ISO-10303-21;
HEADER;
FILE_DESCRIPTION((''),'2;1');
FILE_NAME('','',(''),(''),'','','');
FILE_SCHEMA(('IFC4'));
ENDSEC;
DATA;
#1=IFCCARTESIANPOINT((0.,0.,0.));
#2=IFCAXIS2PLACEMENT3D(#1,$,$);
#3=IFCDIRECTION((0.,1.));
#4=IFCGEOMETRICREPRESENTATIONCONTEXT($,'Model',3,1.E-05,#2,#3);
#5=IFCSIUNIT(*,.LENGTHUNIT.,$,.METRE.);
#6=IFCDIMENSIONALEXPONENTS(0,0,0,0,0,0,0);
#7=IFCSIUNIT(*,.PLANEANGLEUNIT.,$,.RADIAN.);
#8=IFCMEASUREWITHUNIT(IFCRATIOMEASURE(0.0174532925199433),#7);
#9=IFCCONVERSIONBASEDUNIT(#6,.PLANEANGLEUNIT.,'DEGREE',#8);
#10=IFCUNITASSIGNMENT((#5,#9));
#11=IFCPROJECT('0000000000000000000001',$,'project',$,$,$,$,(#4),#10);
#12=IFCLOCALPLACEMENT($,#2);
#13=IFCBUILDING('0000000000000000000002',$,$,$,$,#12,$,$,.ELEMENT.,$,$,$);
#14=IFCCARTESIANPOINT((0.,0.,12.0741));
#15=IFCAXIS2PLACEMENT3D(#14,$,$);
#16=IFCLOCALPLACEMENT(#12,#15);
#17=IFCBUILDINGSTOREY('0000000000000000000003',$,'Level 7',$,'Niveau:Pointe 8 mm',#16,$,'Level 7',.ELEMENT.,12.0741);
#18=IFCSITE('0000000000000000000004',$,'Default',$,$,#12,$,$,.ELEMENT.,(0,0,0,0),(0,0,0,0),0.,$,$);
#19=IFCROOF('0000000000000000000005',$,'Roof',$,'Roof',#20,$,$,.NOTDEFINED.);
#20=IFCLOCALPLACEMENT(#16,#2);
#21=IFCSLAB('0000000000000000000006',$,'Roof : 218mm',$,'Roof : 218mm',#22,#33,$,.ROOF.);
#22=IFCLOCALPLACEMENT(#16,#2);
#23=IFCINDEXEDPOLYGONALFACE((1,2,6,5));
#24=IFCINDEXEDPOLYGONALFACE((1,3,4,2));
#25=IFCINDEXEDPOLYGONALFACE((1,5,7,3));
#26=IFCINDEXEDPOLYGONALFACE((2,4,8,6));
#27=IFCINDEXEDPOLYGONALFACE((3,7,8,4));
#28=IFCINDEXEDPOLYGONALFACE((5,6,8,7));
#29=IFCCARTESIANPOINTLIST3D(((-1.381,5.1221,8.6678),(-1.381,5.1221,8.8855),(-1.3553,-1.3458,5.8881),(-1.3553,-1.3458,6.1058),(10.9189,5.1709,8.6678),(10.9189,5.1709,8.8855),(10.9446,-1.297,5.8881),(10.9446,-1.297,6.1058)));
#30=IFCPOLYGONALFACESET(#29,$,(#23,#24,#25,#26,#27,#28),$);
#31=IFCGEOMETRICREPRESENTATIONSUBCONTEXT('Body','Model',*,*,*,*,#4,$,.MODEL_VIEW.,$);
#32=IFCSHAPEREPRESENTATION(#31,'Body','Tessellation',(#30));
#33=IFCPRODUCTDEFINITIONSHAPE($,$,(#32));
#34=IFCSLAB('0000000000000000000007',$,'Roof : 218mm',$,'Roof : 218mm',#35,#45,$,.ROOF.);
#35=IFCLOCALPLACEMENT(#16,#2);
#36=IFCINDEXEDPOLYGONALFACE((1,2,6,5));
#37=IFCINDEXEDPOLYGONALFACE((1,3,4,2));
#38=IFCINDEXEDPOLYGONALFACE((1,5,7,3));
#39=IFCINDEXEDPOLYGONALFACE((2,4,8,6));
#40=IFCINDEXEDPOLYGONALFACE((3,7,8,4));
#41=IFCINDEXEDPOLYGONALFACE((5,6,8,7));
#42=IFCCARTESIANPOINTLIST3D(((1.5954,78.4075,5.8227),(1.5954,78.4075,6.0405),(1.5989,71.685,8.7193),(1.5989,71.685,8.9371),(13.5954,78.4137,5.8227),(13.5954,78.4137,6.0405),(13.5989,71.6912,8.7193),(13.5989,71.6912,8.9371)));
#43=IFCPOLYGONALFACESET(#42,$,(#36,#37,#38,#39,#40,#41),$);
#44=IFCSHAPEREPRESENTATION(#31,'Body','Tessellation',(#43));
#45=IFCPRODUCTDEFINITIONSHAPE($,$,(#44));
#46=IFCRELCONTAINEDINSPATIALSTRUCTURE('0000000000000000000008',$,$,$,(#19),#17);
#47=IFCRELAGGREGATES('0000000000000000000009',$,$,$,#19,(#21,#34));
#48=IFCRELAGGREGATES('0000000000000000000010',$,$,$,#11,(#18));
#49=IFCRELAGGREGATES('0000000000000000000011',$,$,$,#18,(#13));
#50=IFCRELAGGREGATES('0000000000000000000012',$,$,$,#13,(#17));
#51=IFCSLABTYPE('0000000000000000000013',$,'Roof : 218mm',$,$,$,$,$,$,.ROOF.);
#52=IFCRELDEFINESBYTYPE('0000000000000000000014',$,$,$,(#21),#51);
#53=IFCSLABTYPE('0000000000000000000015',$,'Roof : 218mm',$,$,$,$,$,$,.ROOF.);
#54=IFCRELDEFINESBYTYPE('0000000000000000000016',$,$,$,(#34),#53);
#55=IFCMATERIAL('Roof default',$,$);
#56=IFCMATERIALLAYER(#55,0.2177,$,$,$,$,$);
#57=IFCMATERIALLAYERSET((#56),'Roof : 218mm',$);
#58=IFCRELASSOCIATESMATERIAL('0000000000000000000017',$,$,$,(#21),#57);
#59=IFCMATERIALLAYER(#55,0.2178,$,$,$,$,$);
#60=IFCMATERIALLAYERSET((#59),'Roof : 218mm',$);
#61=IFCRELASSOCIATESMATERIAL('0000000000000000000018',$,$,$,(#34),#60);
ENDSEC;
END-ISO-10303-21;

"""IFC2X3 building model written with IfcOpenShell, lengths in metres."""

from ifc_helpers import new_model, entity, si_unit, converted_unit, direction, frame, origin, place, context, subcontext, project, spatial, polyline, outline, extrude, material, layer, layer_set, type_object, element, aggregate, save


model = new_model("IFC2X3")

# Units and contexts
model_context = context("Model", 3, precision=1e-05, world=origin(), true_north=direction((0.0, 1.0)))
body_context = subcontext(model_context, "Body", "Model", "MODEL_VIEW")
ifc_project = project(units=[si_unit("LENGTHUNIT", "METRE"), converted_unit("PLANEANGLEUNIT", "DEGREE", entity("IfcRatioMeasure", 0.0174532925199433), si_unit("PLANEANGLEUNIT", "RADIAN"), dimensions=[0, 0, 0, 0, 0, 0, 0])], contexts=[model_context])

# Site, building, storey
placement_1 = place(None, origin())
site = spatial("IfcSite", under=ifc_project, at=placement_1, Name="Default", CompositionType="ELEMENT", RefLatitude=(0, 0, 0, 0), RefLongitude=(0, 0, 0, 0), RefElevation=0.0)
building = spatial("IfcBuilding", under=site, at=placement_1, CompositionType="ELEMENT")
storey_placement = place(placement_1, frame((0.0, 0.0, 12.0741)))
storey = spatial("IfcBuildingStorey", under=building, at=storey_placement, Name="Level 7", ObjectType="Niveau:Pointe 8 mm", LongName="Level 7", CompositionType="ELEMENT", Elevation=12.0741)

# Roof, slabs
placement_2 = place(storey_placement, frame((7.3919, 25.537, 0.0)))
roof = element("IfcRoof", 1, at=placement_2, inside=storey, Name="Roof", ObjectType="Roof", ShapeType="NOTDEFINED")
ifc_material = material(Name="Roof default")
ifc_layer_1 = layer(ifc_material, 0.2177)
ifc_layer_set_1 = layer_set([ifc_layer_1], Name="Roof : 218mm")
slab_type_1 = type_object("IfcSlabType", Name="Roof : 218mm", PredefinedType="ROOF")
slab_1 = element("IfcSlab", 2, at=placement_2, type_object=slab_type_1, material=ifc_layer_set_1, Name="Roof : 218mm", ObjectType="Roof : 218mm", PredefinedType="ROOF", context=body_context, shape_type="SweptSolid", body=[
    extrude(outline(polyline([(-6.15, -3.52), (6.15, -3.52), (6.15, 3.52), (-6.15, 3.52), (-6.15, -3.52)])), frame((-2.6101, -23.6244, 7.4956), z_axis=(0.001567, -0.394848, 0.918745), x_axis=(0.999992, 0.003968, 0.0)), (0.0, -0.394851, -0.918745), 0.2177),
])
ifc_layer_2 = layer(ifc_material, 0.2178)
ifc_layer_set_2 = layer_set([ifc_layer_2], Name="Roof : 218mm")
slab_type_2 = type_object("IfcSlabType", Name="Roof : 218mm", PredefinedType="ROOF")
slab_2 = element("IfcSlab", 3, at=placement_2, type_object=slab_type_2, material=ifc_layer_set_2, Name="Roof : 218mm", ObjectType="Roof : 218mm", PredefinedType="ROOF", context=body_context, shape_type="SweptSolid", body=[
    extrude(outline(polyline([(-6.0, -3.66), (6.0, -3.66), (6.0, 3.66), (-6.0, 3.66), (-6.0, -3.66)])), frame((0.2052, 49.5124, 7.4888), z_axis=(-0.000204, 0.395712, 0.918375), x_axis=(-1.0, -0.000516, 0.0)), (0.0, -0.395712, -0.918375), 0.2178),
])
aggregate(roof, [slab_1, slab_2])

save(model, "model.ifc")
